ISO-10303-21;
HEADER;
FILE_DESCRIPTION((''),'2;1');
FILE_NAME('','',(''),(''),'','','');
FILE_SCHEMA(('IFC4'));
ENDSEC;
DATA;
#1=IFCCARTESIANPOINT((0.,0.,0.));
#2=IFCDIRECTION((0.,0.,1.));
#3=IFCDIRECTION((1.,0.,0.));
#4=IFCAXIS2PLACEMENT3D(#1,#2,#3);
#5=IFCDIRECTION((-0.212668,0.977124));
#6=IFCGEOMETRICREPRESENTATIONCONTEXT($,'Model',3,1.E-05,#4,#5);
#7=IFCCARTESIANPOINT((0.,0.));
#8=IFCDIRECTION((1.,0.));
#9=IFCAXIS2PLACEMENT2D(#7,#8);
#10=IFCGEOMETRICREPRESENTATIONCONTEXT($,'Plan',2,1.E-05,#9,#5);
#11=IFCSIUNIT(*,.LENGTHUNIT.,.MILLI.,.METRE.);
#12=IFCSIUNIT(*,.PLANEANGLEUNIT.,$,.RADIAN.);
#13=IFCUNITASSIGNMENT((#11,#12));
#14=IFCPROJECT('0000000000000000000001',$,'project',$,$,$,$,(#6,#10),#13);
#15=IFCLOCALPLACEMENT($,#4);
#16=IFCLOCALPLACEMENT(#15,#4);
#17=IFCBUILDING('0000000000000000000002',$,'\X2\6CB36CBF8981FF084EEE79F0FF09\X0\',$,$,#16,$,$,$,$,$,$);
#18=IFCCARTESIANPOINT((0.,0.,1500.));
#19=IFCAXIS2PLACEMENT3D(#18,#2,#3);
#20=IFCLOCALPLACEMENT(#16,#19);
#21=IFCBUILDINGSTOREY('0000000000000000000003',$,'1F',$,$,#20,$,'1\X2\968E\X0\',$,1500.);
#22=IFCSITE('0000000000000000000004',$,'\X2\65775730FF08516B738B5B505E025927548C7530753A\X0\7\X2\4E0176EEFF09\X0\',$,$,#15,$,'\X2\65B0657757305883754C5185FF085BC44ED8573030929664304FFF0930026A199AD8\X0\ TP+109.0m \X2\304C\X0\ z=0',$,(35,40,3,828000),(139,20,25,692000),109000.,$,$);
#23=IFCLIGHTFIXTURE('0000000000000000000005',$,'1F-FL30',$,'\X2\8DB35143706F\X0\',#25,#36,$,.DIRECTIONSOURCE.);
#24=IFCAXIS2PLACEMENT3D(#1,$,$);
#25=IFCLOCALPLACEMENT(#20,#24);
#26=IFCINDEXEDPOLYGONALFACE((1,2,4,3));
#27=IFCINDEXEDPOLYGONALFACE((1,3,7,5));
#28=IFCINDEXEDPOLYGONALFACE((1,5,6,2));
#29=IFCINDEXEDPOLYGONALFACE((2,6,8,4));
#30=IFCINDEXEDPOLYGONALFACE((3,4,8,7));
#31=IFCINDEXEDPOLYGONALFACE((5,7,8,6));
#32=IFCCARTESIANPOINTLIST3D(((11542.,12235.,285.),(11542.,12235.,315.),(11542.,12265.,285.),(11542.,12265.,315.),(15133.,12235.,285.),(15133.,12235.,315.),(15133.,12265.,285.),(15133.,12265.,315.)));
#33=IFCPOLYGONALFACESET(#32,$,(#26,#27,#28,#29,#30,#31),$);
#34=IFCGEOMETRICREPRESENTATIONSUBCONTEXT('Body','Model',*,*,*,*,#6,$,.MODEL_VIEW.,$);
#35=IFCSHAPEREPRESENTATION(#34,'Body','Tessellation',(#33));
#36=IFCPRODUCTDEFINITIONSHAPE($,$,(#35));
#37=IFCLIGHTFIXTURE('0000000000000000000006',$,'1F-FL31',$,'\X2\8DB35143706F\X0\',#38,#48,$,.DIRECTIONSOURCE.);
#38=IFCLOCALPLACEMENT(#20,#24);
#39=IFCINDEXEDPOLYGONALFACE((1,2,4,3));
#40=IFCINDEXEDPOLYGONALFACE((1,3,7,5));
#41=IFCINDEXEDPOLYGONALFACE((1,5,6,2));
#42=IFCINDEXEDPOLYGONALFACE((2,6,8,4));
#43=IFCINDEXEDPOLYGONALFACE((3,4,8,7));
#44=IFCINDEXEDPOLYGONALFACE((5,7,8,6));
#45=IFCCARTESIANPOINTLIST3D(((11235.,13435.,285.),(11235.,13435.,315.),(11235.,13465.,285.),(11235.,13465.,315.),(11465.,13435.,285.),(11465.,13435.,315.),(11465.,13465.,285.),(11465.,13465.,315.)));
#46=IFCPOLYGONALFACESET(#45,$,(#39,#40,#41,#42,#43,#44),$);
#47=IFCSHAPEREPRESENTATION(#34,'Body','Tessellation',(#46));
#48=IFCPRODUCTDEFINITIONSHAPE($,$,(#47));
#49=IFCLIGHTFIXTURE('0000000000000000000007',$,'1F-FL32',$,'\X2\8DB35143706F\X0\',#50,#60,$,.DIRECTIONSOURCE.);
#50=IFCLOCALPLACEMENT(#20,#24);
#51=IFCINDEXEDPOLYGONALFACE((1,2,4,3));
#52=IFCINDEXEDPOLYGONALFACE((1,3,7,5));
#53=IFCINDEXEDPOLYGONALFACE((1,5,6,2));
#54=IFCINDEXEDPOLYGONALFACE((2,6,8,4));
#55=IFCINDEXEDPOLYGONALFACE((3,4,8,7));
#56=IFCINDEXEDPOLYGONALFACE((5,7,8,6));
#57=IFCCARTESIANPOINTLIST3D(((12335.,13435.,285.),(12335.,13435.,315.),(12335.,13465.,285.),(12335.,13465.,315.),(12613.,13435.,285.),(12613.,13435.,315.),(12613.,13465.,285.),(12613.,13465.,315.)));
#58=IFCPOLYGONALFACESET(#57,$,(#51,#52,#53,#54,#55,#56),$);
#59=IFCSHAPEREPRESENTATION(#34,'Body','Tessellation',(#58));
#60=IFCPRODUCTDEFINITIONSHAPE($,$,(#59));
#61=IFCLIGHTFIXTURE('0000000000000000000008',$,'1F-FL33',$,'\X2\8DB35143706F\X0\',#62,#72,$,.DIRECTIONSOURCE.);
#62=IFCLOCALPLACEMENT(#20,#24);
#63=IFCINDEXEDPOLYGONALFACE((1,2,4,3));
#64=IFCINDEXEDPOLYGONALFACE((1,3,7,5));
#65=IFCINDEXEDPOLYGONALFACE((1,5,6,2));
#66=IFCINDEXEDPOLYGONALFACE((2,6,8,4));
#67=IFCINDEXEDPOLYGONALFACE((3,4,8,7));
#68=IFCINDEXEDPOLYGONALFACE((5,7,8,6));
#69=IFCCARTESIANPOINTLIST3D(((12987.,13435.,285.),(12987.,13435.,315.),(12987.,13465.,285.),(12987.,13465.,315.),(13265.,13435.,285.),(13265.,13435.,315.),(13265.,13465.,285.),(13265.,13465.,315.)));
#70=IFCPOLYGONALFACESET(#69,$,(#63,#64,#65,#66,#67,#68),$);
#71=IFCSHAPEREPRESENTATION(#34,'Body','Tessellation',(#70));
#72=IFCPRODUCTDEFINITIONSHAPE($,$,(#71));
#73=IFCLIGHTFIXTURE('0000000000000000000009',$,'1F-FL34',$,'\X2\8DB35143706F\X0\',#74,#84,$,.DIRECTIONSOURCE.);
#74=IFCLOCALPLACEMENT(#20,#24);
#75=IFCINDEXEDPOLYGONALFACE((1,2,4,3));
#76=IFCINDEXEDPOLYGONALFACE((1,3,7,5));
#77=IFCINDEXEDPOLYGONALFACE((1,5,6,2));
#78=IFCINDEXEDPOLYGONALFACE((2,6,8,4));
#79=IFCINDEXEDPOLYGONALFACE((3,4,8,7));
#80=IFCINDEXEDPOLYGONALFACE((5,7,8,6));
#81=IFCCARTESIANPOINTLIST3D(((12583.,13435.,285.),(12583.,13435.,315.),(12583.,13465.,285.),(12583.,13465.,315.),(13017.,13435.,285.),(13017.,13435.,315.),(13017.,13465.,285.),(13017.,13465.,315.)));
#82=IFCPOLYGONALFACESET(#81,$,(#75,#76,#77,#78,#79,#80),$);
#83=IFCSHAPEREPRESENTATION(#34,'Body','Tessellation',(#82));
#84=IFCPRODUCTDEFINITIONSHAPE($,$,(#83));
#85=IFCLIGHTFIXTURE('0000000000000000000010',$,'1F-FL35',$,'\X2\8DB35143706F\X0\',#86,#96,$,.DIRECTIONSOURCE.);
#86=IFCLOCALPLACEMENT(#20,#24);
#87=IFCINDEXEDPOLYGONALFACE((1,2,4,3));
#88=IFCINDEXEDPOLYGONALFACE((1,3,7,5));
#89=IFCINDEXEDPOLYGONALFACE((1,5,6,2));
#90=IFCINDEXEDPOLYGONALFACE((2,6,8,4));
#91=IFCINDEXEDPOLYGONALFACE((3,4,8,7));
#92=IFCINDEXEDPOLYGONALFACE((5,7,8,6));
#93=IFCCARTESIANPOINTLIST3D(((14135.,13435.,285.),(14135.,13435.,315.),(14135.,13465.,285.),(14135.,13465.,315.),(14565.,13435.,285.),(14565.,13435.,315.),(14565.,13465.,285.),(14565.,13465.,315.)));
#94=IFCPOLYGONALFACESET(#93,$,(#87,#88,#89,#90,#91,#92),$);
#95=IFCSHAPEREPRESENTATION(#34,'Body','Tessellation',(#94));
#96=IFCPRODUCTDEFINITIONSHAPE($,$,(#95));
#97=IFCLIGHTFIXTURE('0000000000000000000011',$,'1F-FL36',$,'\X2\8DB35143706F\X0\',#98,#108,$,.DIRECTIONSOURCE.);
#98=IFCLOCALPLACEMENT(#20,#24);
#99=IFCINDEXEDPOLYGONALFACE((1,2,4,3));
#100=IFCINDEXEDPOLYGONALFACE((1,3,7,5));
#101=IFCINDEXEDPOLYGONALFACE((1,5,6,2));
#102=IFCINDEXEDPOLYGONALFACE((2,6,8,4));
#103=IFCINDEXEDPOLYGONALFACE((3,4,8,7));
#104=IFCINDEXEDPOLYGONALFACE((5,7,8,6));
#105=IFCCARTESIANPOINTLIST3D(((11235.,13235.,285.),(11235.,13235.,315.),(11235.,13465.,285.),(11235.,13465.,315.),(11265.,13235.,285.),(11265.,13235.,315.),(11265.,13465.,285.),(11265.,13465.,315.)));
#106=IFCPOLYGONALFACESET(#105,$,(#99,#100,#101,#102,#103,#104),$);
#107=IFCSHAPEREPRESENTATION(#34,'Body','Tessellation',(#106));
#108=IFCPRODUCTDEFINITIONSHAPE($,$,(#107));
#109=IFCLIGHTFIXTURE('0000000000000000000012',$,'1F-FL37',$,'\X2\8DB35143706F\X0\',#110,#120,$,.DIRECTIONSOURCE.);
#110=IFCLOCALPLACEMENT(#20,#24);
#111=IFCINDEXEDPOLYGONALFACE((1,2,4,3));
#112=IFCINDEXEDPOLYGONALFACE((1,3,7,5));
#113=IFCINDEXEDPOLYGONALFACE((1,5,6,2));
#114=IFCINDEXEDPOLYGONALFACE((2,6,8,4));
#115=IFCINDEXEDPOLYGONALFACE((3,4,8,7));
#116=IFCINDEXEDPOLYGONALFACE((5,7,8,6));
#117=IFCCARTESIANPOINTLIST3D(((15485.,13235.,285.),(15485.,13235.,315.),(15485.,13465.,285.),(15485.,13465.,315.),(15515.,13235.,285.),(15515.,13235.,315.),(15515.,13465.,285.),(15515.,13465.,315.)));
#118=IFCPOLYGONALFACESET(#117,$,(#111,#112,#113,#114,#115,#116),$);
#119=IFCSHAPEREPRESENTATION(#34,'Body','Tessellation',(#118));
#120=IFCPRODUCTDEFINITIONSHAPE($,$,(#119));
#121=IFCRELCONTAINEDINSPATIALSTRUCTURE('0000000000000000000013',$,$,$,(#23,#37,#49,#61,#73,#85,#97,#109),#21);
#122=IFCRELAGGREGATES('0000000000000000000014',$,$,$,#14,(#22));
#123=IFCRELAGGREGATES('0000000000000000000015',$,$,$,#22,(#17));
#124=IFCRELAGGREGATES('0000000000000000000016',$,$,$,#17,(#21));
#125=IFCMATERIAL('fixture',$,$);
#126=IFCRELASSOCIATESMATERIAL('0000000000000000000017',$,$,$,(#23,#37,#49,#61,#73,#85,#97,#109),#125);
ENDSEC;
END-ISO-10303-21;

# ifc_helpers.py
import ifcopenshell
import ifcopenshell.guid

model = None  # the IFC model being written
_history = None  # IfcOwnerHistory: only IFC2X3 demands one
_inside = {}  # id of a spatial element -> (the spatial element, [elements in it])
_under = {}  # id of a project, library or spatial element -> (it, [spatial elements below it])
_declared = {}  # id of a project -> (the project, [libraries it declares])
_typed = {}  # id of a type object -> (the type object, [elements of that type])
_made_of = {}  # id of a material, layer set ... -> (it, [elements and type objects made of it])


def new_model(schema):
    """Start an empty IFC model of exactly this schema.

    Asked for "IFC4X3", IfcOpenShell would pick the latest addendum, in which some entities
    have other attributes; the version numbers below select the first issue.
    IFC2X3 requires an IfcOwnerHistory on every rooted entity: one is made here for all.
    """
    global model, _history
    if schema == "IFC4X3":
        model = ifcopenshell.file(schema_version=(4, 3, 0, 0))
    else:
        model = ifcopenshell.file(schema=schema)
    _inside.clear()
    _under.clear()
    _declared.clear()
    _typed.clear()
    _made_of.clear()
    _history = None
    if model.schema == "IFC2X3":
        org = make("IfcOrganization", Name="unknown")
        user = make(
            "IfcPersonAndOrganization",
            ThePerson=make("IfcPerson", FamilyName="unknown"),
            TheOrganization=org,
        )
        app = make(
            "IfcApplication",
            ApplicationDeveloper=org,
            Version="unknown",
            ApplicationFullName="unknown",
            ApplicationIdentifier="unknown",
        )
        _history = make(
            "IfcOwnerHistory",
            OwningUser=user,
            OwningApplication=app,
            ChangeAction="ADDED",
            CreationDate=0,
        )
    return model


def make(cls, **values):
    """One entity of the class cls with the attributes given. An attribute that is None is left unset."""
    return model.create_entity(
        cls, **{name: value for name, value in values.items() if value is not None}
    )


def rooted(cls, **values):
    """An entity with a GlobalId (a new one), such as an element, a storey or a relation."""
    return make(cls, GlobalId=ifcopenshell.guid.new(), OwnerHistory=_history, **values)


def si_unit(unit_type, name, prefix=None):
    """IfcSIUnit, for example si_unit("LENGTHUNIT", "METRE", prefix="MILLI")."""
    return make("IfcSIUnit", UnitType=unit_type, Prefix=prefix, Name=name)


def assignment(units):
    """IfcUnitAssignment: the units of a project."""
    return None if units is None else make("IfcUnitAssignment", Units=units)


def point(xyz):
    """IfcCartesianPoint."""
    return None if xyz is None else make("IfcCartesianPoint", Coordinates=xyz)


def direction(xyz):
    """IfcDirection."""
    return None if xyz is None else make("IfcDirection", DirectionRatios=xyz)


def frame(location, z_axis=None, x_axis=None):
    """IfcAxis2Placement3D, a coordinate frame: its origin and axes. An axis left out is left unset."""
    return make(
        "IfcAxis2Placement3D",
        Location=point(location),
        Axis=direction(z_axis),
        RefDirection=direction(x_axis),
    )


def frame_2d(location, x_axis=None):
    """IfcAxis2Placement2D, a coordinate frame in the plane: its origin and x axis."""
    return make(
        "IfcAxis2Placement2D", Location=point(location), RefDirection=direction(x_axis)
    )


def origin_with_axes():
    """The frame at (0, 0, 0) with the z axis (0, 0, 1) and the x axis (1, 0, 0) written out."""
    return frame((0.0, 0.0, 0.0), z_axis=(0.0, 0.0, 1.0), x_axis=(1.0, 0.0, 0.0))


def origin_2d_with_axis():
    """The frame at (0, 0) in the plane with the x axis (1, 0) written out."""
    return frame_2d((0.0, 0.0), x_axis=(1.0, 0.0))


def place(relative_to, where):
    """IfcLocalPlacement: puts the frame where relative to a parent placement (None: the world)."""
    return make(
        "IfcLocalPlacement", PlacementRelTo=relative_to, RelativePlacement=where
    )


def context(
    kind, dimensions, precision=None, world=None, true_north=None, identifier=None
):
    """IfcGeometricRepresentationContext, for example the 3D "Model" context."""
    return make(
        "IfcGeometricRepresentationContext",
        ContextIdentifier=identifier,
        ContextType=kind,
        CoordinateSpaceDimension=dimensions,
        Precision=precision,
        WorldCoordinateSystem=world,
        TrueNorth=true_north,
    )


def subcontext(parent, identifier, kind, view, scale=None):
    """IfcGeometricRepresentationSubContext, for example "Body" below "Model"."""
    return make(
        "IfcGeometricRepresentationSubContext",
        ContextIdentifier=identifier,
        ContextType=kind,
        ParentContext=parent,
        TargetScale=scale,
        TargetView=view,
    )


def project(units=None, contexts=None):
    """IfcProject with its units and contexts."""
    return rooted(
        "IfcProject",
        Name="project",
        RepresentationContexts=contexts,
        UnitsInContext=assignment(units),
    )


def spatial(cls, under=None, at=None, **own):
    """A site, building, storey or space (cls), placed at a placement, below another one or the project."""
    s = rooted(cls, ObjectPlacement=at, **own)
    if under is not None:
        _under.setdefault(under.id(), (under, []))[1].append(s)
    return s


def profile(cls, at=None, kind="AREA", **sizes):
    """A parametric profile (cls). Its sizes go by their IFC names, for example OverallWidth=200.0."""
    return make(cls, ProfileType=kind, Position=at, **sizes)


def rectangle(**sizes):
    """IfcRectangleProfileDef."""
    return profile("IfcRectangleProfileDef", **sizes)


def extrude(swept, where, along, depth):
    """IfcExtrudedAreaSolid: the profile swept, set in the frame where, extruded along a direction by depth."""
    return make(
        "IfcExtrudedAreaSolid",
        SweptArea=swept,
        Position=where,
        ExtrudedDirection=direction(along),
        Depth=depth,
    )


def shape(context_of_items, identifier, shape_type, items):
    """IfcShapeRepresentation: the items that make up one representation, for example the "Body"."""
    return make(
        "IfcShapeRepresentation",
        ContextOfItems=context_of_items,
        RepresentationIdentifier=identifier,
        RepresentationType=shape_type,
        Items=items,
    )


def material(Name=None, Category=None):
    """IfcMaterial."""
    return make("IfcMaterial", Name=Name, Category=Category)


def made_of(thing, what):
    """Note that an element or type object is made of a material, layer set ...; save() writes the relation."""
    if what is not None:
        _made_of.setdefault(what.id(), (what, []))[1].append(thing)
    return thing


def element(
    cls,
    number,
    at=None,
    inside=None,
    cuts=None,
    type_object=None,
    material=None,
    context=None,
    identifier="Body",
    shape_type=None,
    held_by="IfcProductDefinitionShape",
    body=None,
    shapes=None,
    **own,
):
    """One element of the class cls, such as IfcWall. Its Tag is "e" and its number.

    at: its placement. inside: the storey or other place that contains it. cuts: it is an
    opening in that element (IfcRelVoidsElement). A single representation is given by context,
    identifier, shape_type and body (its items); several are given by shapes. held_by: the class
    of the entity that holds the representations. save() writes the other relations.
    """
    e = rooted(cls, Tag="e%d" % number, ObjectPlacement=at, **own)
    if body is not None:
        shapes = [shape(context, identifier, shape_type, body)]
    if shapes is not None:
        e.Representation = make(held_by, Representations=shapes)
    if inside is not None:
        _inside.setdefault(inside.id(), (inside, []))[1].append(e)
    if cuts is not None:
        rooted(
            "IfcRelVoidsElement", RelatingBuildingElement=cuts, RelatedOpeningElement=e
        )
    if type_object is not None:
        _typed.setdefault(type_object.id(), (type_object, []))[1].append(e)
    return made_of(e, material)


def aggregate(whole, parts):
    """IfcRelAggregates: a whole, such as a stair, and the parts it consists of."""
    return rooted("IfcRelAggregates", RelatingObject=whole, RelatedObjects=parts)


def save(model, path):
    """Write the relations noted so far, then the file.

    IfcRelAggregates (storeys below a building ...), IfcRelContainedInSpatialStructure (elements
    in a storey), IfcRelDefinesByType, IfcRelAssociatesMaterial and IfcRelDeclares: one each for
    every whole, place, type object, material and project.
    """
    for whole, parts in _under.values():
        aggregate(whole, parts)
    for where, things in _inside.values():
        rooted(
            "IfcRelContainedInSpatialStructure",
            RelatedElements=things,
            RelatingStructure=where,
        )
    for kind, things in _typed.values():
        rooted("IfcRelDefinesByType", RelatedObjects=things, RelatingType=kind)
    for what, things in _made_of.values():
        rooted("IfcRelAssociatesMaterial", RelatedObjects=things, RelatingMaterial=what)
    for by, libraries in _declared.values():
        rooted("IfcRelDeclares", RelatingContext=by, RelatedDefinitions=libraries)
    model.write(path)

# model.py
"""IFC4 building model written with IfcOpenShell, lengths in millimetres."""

from ifc_helpers import new_model, si_unit, direction, frame, frame_2d, origin_with_axes, origin_2d_with_axis, place, context, subcontext, project, spatial, rectangle, extrude, material, element, save


model = new_model("IFC4")

# Units and contexts
model_context = context("Model", 3, precision=1e-05, world=origin_with_axes(), true_north=direction((-0.212668, 0.977124)))
plan_context = context("Plan", 2, precision=1e-05, world=origin_2d_with_axis(), true_north=direction((-0.212668, 0.977124)))
body_context = subcontext(model_context, "Body", "Model", "MODEL_VIEW")
ifc_project = project(units=[si_unit("LENGTHUNIT", "METRE", prefix="MILLI"), si_unit("PLANEANGLEUNIT", "RADIAN")], contexts=[model_context, plan_context])

# Site, building, storey
site_placement = place(None, origin_with_axes())
site = spatial("IfcSite", under=ifc_project, at=site_placement, Name="敷地（八王子市大和田町7丁目）", LongName="新敷地境界内（寄付地を除く）。標高 TP+109.0m が z=0", RefLatitude=(35, 40, 3, 828000), RefLongitude=(139, 20, 25, 692000), RefElevation=109000.0)
building_placement = place(site_placement, origin_with_axes())
building = spatial("IfcBuilding", under=site, at=building_placement, Name="河沿要（仮称）")
storey_placement = place(building_placement, frame((0.0, 0.0, 1500.0), z_axis=(0.0, 0.0, 1.0), x_axis=(1.0, 0.0, 0.0)))
storey = spatial("IfcBuildingStorey", under=building, at=storey_placement, Name="1F", LongName="1階", Elevation=1500.0)

# Light fixtures
ifc_material = material(Name="fixture")
light_fixture_1_placement = place(storey_placement, origin_with_axes())
element("IfcLightFixture", 1, at=light_fixture_1_placement, inside=storey, material=ifc_material, Name="1F-FL30", ObjectType="足元灯", PredefinedType="DIRECTIONSOURCE", context=body_context, shape_type="SweptSolid", body=[
    extrude(rectangle(XDim=3591.0, YDim=30.0, at=frame_2d((13337.5, 12250.0))), frame((0.0, 0.0, 285.0)), (0.0, 0.0, 1.0), 30.0),
])
light_fixture_2_placement = place(storey_placement, origin_with_axes())
element("IfcLightFixture", 2, at=light_fixture_2_placement, inside=storey, material=ifc_material, Name="1F-FL31", ObjectType="足元灯", PredefinedType="DIRECTIONSOURCE", context=body_context, shape_type="SweptSolid", body=[
    extrude(rectangle(XDim=230.0, YDim=30.0, at=frame_2d((11350.0, 13450.0))), frame((0.0, 0.0, 285.0)), (0.0, 0.0, 1.0), 30.0),
])
light_fixture_3_placement = place(storey_placement, origin_with_axes())
element("IfcLightFixture", 3, at=light_fixture_3_placement, inside=storey, material=ifc_material, Name="1F-FL32", ObjectType="足元灯", PredefinedType="DIRECTIONSOURCE", context=body_context, shape_type="SweptSolid", body=[
    extrude(rectangle(XDim=278.0, YDim=30.0, at=frame_2d((12474.0, 13450.0))), frame((0.0, 0.0, 285.0)), (0.0, 0.0, 1.0), 30.0),
])
light_fixture_4_placement = place(storey_placement, origin_with_axes())
element("IfcLightFixture", 4, at=light_fixture_4_placement, inside=storey, material=ifc_material, Name="1F-FL33", ObjectType="足元灯", PredefinedType="DIRECTIONSOURCE", context=body_context, shape_type="SweptSolid", body=[
    extrude(rectangle(XDim=278.0, YDim=30.0, at=frame_2d((13126.0, 13450.0))), frame((0.0, 0.0, 285.0)), (0.0, 0.0, 1.0), 30.0),
])
light_fixture_5_placement = place(storey_placement, origin_with_axes())
element("IfcLightFixture", 5, at=light_fixture_5_placement, inside=storey, material=ifc_material, Name="1F-FL34", ObjectType="足元灯", PredefinedType="DIRECTIONSOURCE", context=body_context, shape_type="SweptSolid", body=[
    extrude(rectangle(XDim=434.0, YDim=30.0, at=frame_2d((12800.0, 13450.0))), frame((0.0, 0.0, 285.0)), (0.0, 0.0, 1.0), 30.0),
])
light_fixture_6_placement = place(storey_placement, origin_with_axes())
element("IfcLightFixture", 6, at=light_fixture_6_placement, inside=storey, material=ifc_material, Name="1F-FL35", ObjectType="足元灯", PredefinedType="DIRECTIONSOURCE", context=body_context, shape_type="SweptSolid", body=[
    extrude(rectangle(XDim=430.0, YDim=30.0, at=frame_2d((14350.0, 13450.0))), frame((0.0, 0.0, 285.0)), (0.0, 0.0, 1.0), 30.0),
])
light_fixture_7_placement = place(storey_placement, origin_with_axes())
element("IfcLightFixture", 7, at=light_fixture_7_placement, inside=storey, material=ifc_material, Name="1F-FL36", ObjectType="足元灯", PredefinedType="DIRECTIONSOURCE", context=body_context, shape_type="SweptSolid", body=[
    extrude(rectangle(XDim=30.0, YDim=230.0, at=frame_2d((11250.0, 13350.0))), frame((0.0, 0.0, 285.0)), (0.0, 0.0, 1.0), 30.0),
])
light_fixture_8_placement = place(storey_placement, origin_with_axes())
element("IfcLightFixture", 8, at=light_fixture_8_placement, inside=storey, material=ifc_material, Name="1F-FL37", ObjectType="足元灯", PredefinedType="DIRECTIONSOURCE", context=body_context, shape_type="SweptSolid", body=[
    extrude(rectangle(XDim=30.0, YDim=230.0, at=frame_2d((15500.0, 13350.0))), frame((0.0, 0.0, 285.0)), (0.0, 0.0, 1.0), 30.0),
])

save(model, "model.ifc")
